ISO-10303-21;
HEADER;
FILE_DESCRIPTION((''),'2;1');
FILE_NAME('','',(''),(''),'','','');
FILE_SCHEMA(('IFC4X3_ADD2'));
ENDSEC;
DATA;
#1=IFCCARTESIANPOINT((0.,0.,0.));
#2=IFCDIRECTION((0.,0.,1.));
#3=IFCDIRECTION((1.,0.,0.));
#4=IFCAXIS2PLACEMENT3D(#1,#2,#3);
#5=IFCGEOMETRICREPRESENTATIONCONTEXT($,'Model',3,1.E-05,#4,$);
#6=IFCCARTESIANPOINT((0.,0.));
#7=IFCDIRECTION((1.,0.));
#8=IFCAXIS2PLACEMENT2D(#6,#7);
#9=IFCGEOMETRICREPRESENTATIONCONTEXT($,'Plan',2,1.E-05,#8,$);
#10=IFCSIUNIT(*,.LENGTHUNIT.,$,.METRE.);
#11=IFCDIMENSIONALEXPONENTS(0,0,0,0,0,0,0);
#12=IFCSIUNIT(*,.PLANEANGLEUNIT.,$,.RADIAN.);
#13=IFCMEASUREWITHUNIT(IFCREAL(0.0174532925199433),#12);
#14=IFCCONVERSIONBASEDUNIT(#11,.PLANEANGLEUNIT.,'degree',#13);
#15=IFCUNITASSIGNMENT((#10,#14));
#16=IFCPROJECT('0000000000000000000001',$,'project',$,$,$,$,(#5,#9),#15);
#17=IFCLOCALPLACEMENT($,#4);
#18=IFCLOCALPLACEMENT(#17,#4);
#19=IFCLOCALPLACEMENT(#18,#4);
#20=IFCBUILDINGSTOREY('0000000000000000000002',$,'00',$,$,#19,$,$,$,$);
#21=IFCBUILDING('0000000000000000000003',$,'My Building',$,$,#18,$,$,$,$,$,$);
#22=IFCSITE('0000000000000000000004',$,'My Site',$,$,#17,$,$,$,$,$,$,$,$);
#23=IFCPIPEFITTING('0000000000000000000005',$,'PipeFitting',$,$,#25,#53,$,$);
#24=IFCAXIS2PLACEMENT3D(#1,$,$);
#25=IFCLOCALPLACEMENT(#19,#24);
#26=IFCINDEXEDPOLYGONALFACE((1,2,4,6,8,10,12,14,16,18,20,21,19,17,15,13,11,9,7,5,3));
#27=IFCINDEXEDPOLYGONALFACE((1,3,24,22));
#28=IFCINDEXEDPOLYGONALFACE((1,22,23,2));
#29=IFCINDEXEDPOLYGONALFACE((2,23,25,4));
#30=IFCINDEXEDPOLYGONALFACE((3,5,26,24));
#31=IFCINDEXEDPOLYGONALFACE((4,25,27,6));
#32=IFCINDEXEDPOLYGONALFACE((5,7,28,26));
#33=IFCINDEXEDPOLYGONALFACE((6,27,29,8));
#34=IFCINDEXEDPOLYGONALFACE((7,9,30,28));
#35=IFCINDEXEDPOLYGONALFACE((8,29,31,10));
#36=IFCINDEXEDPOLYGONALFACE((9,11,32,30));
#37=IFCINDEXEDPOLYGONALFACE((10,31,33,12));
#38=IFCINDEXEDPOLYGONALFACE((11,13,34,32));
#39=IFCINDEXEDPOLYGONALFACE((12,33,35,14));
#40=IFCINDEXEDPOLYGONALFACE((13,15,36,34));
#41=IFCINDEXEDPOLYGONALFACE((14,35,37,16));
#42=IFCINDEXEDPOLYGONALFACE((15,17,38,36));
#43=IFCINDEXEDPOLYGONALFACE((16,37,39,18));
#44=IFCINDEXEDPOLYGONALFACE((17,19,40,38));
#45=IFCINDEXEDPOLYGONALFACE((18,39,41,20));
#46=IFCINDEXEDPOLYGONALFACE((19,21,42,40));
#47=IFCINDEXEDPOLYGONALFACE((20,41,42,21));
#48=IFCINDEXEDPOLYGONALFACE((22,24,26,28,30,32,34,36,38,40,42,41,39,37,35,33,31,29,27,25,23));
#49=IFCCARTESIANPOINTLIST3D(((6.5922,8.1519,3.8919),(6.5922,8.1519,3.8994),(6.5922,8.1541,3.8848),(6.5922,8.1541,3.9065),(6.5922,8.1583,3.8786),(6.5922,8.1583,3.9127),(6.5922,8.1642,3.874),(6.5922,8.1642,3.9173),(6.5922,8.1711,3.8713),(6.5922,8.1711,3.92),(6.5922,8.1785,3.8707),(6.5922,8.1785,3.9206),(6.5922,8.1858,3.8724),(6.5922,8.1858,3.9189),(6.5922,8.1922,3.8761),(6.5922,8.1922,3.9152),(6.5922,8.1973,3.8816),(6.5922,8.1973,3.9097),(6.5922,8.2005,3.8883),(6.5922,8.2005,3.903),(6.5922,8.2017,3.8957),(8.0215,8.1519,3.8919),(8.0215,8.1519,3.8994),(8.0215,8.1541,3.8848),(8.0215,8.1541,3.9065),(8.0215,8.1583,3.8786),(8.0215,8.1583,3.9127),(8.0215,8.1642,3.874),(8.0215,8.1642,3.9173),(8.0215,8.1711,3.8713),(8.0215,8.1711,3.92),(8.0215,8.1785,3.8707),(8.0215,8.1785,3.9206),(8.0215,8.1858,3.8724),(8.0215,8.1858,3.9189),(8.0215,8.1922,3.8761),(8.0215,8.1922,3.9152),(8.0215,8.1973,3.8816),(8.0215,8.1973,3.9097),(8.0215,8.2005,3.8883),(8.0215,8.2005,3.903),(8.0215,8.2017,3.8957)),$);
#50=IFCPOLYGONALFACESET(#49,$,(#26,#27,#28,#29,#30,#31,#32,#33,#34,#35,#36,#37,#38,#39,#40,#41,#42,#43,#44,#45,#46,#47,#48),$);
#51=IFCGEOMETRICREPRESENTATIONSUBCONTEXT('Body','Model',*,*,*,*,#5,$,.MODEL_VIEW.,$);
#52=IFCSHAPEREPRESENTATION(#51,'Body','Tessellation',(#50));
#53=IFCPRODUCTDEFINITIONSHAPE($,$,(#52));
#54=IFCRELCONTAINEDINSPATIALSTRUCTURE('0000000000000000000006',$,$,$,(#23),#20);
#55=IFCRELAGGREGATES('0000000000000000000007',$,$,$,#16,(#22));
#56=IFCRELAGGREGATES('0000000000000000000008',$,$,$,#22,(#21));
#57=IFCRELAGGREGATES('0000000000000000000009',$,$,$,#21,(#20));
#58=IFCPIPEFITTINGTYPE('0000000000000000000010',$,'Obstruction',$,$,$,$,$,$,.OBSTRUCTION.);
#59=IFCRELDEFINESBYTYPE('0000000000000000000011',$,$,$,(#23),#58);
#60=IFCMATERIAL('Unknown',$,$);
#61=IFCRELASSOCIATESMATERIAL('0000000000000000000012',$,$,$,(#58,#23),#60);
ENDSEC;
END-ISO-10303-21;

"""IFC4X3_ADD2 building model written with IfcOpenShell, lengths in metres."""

from ifc_helpers import new_model, entity, si_unit, converted_unit, frame, origin_with_axes, origin_2d_with_axis, place, context, subcontext, project, spatial, circle, extrude, material, material_profile, profile_set, profile_usage, type_object, element, save


model = new_model("IFC4X3_ADD2")

# Units and contexts
model_context = context("Model", 3, precision=1e-05, world=origin_with_axes())
plan_context = context("Plan", 2, precision=1e-05, world=origin_2d_with_axis())
body_context = subcontext(model_context, "Body", "Model", "MODEL_VIEW")
ifc_project = project(units=[si_unit("LENGTHUNIT", "METRE"), converted_unit("PLANEANGLEUNIT", "degree", entity("IfcReal", 0.0174532925199433), si_unit("PLANEANGLEUNIT", "RADIAN"), dimensions=[0, 0, 0, 0, 0, 0, 0])], contexts=[model_context, plan_context])

# Site, building, storey
site_placement = place(None, origin_with_axes())
site = spatial("IfcSite", under=ifc_project, at=site_placement, Name="My Site")
building_placement = place(site_placement, origin_with_axes())
building = spatial("IfcBuilding", under=site, at=building_placement, Name="My Building")
storey_placement = place(building_placement, origin_with_axes())
storey = spatial("IfcBuildingStorey", under=building, at=storey_placement, Name="00")

# Shared definitions
ifc_material = material(Name="Unknown")

# Pipe fitting
ifc_material_profile = material_profile(ifc_material, circle(Radius=0.025))
ifc_profile_set = profile_set([ifc_material_profile])
ifc_profile_usage = profile_usage(ifc_profile_set, cardinal=5)
pipe_fitting_type = type_object("IfcPipeFittingType", Name="Obstruction", PredefinedType="OBSTRUCTION", material=ifc_profile_set)
pipe_fitting_placement = place(storey_placement, frame((6.5922, 8.1767, 3.8957), z_axis=(1.0, 0.0, 0.0), x_axis=(0.0, 1.0, 0.0)))
element("IfcPipeFitting", 1, at=pipe_fitting_placement, inside=storey, type_object=pipe_fitting_type, material=ifc_profile_usage, Name="PipeFitting", context=body_context, shape_type="SweptSolid", body=[
    extrude(circle(Radius=0.025), origin_with_axes(), (0.0, 0.0, 1.0), 1.4294),
])

save(model, "model.ifc")
